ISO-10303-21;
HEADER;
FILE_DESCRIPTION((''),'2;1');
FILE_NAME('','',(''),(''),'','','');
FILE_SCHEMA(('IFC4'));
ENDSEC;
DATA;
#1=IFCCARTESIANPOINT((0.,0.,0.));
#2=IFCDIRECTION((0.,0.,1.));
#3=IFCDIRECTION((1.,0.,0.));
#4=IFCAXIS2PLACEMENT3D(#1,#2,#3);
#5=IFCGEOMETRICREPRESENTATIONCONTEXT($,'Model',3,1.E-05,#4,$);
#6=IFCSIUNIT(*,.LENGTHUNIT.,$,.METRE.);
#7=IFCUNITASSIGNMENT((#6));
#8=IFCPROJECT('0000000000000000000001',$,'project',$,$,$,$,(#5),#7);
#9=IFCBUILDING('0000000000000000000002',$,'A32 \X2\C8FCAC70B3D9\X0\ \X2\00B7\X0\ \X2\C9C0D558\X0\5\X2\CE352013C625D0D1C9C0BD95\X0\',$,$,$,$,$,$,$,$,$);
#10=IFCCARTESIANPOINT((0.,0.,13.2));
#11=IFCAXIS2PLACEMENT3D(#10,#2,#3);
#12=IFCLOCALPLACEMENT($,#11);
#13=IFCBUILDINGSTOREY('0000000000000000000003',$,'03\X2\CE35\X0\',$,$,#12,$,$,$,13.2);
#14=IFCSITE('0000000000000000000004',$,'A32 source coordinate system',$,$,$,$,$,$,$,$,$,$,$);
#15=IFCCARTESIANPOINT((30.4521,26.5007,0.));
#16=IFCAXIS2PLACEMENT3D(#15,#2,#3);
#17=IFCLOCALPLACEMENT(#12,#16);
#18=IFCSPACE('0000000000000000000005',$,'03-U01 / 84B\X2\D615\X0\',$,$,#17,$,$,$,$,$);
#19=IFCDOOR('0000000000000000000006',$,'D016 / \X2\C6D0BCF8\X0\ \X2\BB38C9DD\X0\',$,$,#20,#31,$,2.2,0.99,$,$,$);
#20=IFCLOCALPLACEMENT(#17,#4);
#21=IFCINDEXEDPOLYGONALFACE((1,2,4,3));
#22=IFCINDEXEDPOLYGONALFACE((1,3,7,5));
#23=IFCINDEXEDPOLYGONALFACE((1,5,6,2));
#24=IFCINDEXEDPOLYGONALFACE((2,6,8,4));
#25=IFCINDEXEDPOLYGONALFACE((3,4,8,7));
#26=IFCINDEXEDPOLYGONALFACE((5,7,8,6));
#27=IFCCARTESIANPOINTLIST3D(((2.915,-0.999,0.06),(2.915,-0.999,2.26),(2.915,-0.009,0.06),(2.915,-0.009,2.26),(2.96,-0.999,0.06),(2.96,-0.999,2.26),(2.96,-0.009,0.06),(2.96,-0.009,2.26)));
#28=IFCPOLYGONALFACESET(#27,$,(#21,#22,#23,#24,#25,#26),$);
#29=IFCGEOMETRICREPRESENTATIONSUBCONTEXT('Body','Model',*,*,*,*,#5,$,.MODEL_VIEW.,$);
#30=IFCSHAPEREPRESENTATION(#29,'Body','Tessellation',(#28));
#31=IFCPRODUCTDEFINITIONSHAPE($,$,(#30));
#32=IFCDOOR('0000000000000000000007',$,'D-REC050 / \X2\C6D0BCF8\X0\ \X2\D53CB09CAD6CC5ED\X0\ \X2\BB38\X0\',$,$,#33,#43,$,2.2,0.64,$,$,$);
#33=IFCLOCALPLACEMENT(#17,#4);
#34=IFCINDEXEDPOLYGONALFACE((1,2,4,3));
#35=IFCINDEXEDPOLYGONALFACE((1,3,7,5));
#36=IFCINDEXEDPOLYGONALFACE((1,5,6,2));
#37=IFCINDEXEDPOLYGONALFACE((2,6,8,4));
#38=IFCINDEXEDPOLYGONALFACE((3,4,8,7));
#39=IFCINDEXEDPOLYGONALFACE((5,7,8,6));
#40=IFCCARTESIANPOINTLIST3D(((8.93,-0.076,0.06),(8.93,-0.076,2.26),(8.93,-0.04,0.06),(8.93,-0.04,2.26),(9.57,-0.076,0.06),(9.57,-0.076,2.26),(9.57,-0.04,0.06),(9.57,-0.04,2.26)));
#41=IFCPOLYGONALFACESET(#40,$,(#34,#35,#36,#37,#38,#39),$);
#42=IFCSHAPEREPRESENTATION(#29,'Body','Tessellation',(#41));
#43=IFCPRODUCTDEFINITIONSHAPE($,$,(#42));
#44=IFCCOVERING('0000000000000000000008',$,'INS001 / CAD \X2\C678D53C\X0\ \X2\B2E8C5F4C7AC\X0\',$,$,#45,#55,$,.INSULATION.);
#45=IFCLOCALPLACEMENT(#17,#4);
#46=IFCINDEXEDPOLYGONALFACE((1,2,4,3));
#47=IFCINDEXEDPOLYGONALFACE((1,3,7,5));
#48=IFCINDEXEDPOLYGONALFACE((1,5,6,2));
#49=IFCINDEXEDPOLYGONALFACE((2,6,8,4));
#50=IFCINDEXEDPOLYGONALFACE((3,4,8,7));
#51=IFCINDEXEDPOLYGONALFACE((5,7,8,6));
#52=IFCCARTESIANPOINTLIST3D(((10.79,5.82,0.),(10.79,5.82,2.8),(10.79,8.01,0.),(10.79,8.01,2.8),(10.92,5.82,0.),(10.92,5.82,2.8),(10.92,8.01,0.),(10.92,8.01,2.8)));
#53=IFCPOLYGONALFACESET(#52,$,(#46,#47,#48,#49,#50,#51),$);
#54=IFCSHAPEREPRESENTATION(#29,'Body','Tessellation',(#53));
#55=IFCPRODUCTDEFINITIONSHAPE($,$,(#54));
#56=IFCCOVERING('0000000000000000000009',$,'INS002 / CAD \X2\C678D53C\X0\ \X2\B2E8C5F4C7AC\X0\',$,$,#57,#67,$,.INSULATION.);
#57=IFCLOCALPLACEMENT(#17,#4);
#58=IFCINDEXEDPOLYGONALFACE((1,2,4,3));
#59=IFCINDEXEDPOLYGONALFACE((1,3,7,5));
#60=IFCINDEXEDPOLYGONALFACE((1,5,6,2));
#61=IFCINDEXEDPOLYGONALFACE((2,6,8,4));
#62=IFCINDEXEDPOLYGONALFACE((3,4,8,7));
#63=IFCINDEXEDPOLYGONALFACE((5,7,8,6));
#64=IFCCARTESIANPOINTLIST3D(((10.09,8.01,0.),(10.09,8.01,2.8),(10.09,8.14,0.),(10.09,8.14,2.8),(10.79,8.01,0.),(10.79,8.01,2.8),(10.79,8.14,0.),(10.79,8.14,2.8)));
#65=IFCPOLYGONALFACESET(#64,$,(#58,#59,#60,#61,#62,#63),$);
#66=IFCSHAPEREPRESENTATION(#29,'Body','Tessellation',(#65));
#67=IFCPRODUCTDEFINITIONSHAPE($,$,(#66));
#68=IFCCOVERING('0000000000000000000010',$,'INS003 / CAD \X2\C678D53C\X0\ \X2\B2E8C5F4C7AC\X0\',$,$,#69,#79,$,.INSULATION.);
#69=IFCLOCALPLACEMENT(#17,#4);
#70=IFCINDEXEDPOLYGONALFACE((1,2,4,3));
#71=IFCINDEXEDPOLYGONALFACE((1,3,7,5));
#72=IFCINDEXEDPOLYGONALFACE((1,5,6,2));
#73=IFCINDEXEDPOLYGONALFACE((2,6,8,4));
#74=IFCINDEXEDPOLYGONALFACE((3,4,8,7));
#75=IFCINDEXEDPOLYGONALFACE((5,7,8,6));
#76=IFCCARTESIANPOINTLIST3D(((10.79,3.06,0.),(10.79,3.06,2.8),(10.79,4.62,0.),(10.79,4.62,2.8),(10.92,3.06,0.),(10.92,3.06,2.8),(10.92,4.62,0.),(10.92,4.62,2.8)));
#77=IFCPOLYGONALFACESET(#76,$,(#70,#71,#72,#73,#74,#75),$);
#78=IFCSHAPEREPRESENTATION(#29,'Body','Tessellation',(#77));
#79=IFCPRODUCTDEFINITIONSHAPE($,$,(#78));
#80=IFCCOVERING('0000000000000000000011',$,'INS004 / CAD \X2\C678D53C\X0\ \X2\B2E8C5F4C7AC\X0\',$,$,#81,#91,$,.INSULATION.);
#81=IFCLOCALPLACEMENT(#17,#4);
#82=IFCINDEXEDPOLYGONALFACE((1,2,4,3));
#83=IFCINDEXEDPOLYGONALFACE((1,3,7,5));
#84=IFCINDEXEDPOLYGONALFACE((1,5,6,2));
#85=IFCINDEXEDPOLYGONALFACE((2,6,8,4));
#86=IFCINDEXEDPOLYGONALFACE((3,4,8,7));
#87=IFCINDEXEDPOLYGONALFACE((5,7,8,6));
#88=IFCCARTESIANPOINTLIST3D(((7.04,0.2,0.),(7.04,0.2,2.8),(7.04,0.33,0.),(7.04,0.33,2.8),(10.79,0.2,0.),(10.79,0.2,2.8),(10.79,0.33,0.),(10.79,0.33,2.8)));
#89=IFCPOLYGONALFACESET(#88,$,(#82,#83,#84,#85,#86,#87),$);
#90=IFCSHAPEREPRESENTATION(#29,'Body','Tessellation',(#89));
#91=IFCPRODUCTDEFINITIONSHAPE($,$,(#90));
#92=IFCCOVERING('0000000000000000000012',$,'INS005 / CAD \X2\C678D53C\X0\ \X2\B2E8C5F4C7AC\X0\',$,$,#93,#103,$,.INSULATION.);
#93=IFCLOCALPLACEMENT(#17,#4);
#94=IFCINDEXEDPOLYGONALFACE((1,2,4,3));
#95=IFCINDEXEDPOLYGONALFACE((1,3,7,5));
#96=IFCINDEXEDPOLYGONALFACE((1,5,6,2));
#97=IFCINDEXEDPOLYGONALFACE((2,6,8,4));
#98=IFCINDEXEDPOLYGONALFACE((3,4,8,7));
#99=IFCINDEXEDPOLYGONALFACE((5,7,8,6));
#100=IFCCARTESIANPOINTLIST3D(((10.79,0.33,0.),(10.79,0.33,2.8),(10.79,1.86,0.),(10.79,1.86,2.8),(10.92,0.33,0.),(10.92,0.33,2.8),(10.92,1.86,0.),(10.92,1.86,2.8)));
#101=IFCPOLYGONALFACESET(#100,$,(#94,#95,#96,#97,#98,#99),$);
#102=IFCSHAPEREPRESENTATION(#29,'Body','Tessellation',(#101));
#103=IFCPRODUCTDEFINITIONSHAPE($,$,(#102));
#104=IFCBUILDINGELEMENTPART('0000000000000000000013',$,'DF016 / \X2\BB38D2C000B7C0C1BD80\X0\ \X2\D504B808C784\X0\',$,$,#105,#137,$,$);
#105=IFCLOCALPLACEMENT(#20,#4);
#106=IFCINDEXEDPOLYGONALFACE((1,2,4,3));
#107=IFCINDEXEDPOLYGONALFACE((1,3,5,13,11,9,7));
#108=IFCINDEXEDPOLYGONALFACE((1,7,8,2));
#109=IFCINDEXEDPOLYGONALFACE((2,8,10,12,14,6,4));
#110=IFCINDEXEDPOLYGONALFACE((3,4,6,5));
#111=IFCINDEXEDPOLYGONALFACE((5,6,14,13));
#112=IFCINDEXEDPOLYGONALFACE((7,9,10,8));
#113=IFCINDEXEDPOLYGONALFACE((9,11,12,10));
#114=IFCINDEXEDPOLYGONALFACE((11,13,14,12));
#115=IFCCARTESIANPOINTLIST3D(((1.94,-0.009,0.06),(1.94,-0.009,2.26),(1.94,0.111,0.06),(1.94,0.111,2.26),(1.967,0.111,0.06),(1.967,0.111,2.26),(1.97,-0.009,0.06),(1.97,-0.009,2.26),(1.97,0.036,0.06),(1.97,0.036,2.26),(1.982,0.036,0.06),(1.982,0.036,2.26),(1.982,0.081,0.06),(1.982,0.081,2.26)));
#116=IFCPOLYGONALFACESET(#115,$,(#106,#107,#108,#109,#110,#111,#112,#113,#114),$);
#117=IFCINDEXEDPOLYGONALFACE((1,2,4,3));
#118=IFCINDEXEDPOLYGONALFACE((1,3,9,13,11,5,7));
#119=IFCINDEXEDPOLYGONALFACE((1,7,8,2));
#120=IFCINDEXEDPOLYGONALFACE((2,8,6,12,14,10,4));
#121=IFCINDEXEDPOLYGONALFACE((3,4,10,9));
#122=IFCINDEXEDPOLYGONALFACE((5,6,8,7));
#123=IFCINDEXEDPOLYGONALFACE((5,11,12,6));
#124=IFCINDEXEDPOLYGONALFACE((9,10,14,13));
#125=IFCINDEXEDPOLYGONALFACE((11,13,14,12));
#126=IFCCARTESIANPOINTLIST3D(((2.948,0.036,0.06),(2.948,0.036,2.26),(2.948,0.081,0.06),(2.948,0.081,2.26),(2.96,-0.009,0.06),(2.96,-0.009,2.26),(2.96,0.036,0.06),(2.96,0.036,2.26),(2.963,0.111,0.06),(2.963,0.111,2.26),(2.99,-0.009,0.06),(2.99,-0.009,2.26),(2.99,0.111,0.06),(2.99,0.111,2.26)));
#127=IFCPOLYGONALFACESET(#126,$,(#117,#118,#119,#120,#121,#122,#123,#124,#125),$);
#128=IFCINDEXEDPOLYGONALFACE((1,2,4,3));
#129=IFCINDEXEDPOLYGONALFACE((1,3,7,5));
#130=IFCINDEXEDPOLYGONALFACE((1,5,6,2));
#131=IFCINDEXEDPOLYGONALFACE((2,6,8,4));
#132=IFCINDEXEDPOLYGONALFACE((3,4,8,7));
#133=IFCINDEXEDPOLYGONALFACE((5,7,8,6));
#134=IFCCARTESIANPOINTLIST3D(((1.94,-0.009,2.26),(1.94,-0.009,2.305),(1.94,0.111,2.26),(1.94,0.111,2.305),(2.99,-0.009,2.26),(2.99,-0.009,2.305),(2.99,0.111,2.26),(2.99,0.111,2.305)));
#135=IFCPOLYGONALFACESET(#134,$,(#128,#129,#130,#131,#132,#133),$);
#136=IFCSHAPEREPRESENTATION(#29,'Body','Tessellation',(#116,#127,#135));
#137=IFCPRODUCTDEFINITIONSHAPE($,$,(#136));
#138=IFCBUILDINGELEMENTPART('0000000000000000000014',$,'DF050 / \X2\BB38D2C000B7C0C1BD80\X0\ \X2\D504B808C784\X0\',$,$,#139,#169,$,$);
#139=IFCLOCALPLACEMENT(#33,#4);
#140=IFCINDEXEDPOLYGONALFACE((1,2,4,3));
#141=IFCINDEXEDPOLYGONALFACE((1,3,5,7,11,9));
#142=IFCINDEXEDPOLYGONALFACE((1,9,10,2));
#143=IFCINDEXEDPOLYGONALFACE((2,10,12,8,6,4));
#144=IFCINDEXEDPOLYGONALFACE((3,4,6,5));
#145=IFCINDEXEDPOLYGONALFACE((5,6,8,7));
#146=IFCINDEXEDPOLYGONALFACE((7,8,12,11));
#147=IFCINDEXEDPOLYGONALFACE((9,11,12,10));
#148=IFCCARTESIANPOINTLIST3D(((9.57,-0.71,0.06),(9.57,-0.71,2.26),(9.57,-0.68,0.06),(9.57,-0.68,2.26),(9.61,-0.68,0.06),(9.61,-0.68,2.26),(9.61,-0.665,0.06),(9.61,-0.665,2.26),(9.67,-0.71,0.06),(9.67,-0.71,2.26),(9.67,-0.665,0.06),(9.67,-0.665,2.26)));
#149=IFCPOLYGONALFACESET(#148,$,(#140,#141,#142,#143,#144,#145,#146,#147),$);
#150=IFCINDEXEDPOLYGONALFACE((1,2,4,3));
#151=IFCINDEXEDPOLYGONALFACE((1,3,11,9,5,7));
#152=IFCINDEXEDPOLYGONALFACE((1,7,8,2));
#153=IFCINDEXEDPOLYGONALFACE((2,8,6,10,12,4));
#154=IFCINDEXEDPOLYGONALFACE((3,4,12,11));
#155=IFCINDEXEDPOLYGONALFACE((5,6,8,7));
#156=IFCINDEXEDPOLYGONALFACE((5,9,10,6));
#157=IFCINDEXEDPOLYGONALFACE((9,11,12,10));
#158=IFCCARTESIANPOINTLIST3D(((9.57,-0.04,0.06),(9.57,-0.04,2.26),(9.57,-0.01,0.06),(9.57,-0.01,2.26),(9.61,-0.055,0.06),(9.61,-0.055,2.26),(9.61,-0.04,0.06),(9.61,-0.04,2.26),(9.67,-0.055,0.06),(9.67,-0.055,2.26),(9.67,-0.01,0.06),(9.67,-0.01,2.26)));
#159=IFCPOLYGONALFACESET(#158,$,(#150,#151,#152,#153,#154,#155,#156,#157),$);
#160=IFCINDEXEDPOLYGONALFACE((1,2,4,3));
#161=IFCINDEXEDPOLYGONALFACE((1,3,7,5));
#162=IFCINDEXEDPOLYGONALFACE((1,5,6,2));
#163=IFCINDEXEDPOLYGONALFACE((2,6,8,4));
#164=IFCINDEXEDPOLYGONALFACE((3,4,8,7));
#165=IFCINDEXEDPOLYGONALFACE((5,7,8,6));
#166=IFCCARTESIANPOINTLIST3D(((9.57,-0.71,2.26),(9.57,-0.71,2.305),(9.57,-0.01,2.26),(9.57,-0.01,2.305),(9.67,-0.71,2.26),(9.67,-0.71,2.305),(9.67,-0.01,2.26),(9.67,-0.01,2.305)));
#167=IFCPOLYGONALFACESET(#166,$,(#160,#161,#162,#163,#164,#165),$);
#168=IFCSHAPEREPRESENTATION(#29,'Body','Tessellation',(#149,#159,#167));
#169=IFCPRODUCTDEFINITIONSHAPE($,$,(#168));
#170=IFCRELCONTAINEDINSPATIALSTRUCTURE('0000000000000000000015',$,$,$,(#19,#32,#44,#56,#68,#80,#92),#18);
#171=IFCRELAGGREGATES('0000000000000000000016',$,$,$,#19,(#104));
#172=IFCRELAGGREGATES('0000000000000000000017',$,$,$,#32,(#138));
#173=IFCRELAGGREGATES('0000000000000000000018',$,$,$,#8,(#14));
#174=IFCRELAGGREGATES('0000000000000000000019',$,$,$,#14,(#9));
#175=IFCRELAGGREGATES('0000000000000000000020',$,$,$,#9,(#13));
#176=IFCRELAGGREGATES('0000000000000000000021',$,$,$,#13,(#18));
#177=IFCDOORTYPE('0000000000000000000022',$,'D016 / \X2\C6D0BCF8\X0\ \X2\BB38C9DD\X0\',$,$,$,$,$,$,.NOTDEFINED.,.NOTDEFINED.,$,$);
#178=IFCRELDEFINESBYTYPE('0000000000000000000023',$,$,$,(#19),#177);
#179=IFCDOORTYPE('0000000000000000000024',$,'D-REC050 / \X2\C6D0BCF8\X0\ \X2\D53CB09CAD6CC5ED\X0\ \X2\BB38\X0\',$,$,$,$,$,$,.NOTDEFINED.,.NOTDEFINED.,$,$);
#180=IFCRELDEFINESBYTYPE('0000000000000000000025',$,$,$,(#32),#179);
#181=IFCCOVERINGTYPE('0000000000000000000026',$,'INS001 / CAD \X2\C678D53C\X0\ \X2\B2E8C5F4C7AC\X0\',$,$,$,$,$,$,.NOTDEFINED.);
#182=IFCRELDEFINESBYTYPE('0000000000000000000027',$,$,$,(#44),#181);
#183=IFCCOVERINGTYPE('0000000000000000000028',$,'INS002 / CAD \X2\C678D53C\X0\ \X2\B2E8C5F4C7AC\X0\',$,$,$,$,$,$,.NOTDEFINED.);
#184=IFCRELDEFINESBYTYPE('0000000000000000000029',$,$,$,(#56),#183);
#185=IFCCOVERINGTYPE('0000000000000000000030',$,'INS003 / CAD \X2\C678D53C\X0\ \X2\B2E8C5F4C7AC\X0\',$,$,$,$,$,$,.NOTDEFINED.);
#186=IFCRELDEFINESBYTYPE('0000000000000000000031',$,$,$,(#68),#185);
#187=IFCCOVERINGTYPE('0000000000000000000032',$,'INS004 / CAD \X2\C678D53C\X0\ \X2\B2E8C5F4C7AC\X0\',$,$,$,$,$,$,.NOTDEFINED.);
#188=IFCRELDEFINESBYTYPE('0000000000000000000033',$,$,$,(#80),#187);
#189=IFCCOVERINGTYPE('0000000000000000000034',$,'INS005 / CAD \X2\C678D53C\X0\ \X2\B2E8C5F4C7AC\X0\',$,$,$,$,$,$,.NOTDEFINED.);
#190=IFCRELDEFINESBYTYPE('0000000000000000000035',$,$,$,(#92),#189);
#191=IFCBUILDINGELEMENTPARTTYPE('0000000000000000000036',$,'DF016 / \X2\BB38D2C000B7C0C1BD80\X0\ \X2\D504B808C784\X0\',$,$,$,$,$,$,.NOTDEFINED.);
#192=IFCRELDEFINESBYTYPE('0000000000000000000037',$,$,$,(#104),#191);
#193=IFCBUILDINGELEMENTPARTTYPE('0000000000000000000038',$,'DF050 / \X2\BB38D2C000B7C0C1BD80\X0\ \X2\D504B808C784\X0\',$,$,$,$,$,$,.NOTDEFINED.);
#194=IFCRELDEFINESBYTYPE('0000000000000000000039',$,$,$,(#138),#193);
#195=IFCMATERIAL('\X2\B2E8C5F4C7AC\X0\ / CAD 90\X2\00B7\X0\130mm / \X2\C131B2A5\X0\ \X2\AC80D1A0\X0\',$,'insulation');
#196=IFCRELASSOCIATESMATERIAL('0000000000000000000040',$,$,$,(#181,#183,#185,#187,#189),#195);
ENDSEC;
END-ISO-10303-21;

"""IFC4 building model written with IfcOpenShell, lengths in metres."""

from ifc_helpers import new_model, si_unit, frame, origin, origin_with_axes, place, context, subcontext, project, spatial, polyline, outline, extrude, source, transform, mapped, material, type_object, type_shapes, element, aggregate, save


model = new_model("IFC4")

# Units and contexts
model_context = context("Model", 3, precision=1e-05, world=origin_with_axes())
body_context = subcontext(model_context, "Body", "Model", "MODEL_VIEW")
ifc_project = project(units=[si_unit("LENGTHUNIT", "METRE")], contexts=[model_context])

# Site, building, storey, space
storey_placement = place(None, frame((0.0, 0.0, 13.2), z_axis=(0.0, 0.0, 1.0), x_axis=(1.0, 0.0, 0.0)))
space_placement = place(storey_placement, frame((30.4521, 26.5007, 0.0), z_axis=(0.0, 0.0, 1.0), x_axis=(1.0, 0.0, 0.0)))
site = spatial("IfcSite", under=ifc_project, Name="A32 source coordinate system")
building = spatial("IfcBuilding", under=site, Name="A32 주거동 · 지하5층–옥탑지붕")
storey = spatial("IfcBuildingStorey", under=building, at=storey_placement, Name="03층", Elevation=13.2)
space = spatial("IfcSpace", under=storey, at=space_placement, Name="03-U01 / 84B형")

# Doors
door_type_1 = type_object("IfcDoorType", Name="D016 / 원본 문짝", OperationType="NOTDEFINED", PredefinedType="NOTDEFINED")
shared_shape_1 = source(origin(), body_context, "Body", "SweptSolid", [
    extrude(outline(polyline([(2.96, -0.009), (2.96, -0.999), (2.915, -0.999), (2.915, -0.009), (2.96, -0.009)])), frame((0.0, 0.0, 0.06)), (0.0, 0.0, 1.0), 2.2),
])
type_shapes(door_type_1, [shared_shape_1])
door_1_placement = place(space_placement, origin_with_axes())
door_1 = element("IfcDoor", 1, at=door_1_placement, inside=space, type_object=door_type_1, Name="D016 / 원본 문짝", OverallHeight=2.2, OverallWidth=0.99, context=body_context, shape_type="MappedRepresentation", body=[
    mapped(shared_shape_1, transform((0.0, 0.0, 0.0), scale=1.0)),
])
door_type_2 = type_object("IfcDoorType", Name="D-REC050 / 원본 피난구역 문", OperationType="NOTDEFINED", PredefinedType="NOTDEFINED")
shared_shape_2 = source(origin(), body_context, "Body", "SweptSolid", [
    extrude(outline(polyline([(9.57, -0.04), (9.57, -0.076), (8.93, -0.076), (8.93, -0.04), (9.57, -0.04)])), frame((0.0, 0.0, 0.06)), (0.0, 0.0, 1.0), 2.2),
])
type_shapes(door_type_2, [shared_shape_2])
door_2_placement = place(space_placement, origin_with_axes())
door_2 = element("IfcDoor", 2, at=door_2_placement, inside=space, type_object=door_type_2, Name="D-REC050 / 원본 피난구역 문", OverallHeight=2.2, OverallWidth=0.64, context=body_context, shape_type="MappedRepresentation", body=[
    mapped(shared_shape_2, transform((0.0, 0.0, 0.0), scale=1.0)),
])

# Coverings
ifc_material = material(Name="단열재 / CAD 90·130mm / 성능 검토", Category="insulation")
covering_type_1 = type_object("IfcCoveringType", Name="INS001 / CAD 외피 단열재", PredefinedType="NOTDEFINED", material=ifc_material)
shared_shape_3 = source(origin(), body_context, "Body", "SweptSolid", [
    extrude(outline(polyline([(10.79, 5.82), (10.79, 8.01), (10.92, 8.01), (10.92, 5.82), (10.79, 5.82)])), origin(), (0.0, 0.0, 1.0), 2.8),
])
type_shapes(covering_type_1, [shared_shape_3])
covering_1_placement = place(space_placement, origin_with_axes())
element("IfcCovering", 3, at=covering_1_placement, inside=space, type_object=covering_type_1, Name="INS001 / CAD 외피 단열재", PredefinedType="INSULATION", context=body_context, shape_type="MappedRepresentation", body=[
    mapped(shared_shape_3, transform((0.0, 0.0, 0.0), scale=1.0)),
])
covering_type_2 = type_object("IfcCoveringType", Name="INS002 / CAD 외피 단열재", PredefinedType="NOTDEFINED", material=ifc_material)
shared_shape_4 = source(origin(), body_context, "Body", "SweptSolid", [
    extrude(outline(polyline([(10.79, 8.01), (10.09, 8.01), (10.09, 8.14), (10.79, 8.14), (10.79, 8.01)])), origin(), (0.0, 0.0, 1.0), 2.8),
])
type_shapes(covering_type_2, [shared_shape_4])
covering_2_placement = place(space_placement, origin_with_axes())
element("IfcCovering", 4, at=covering_2_placement, inside=space, type_object=covering_type_2, Name="INS002 / CAD 외피 단열재", PredefinedType="INSULATION", context=body_context, shape_type="MappedRepresentation", body=[
    mapped(shared_shape_4, transform((0.0, 0.0, 0.0), scale=1.0)),
])
covering_type_3 = type_object("IfcCoveringType", Name="INS003 / CAD 외피 단열재", PredefinedType="NOTDEFINED", material=ifc_material)
shared_shape_5 = source(origin(), body_context, "Body", "SweptSolid", [
    extrude(outline(polyline([(10.79, 3.06), (10.79, 4.62), (10.92, 4.62), (10.92, 3.06), (10.79, 3.06)])), origin(), (0.0, 0.0, 1.0), 2.8),
])
type_shapes(covering_type_3, [shared_shape_5])
covering_3_placement = place(space_placement, origin_with_axes())
element("IfcCovering", 5, at=covering_3_placement, inside=space, type_object=covering_type_3, Name="INS003 / CAD 외피 단열재", PredefinedType="INSULATION", context=body_context, shape_type="MappedRepresentation", body=[
    mapped(shared_shape_5, transform((0.0, 0.0, 0.0), scale=1.0)),
])
covering_type_4 = type_object("IfcCoveringType", Name="INS004 / CAD 외피 단열재", PredefinedType="NOTDEFINED", material=ifc_material)
shared_shape_6 = source(origin(), body_context, "Body", "SweptSolid", [
    extrude(outline(polyline([(7.04, 0.33), (10.79, 0.33), (10.79, 0.2), (7.04, 0.2), (7.04, 0.33)])), origin(), (0.0, 0.0, 1.0), 2.8),
])
type_shapes(covering_type_4, [shared_shape_6])
covering_4_placement = place(space_placement, origin_with_axes())
element("IfcCovering", 6, at=covering_4_placement, inside=space, type_object=covering_type_4, Name="INS004 / CAD 외피 단열재", PredefinedType="INSULATION", context=body_context, shape_type="MappedRepresentation", body=[
    mapped(shared_shape_6, transform((0.0, 0.0, 0.0), scale=1.0)),
])
covering_type_5 = type_object("IfcCoveringType", Name="INS005 / CAD 외피 단열재", PredefinedType="NOTDEFINED", material=ifc_material)
shared_shape_7 = source(origin(), body_context, "Body", "SweptSolid", [
    extrude(outline(polyline([(10.79, 0.33), (10.79, 1.86), (10.92, 1.86), (10.92, 0.33), (10.79, 0.33)])), origin(), (0.0, 0.0, 1.0), 2.8),
])
type_shapes(covering_type_5, [shared_shape_7])
covering_5_placement = place(space_placement, origin_with_axes())
element("IfcCovering", 7, at=covering_5_placement, inside=space, type_object=covering_type_5, Name="INS005 / CAD 외피 단열재", PredefinedType="INSULATION", context=body_context, shape_type="MappedRepresentation", body=[
    mapped(shared_shape_7, transform((0.0, 0.0, 0.0), scale=1.0)),
])

# Building element parts
building_element_part_type_1 = type_object("IfcBuildingElementPartType", Name="DF016 / 문틀·상부 프레임", PredefinedType="NOTDEFINED")
shared_shape_8 = source(origin(), body_context, "Body", "SweptSolid", [
    extrude(outline(polyline([(1.94, 0.111), (1.967, 0.111), (1.982, 0.081), (1.982, 0.036), (1.97, 0.036), (1.97, -0.009), (1.94, -0.009), (1.94, 0.111)])), frame((0.0, 0.0, 0.06)), (0.0, 0.0, 1.0), 2.2),
    extrude(outline(polyline([(2.96, -0.009), (2.96, 0.036), (2.948, 0.036), (2.948, 0.081), (2.963, 0.111), (2.99, 0.111), (2.99, -0.009), (2.96, -0.009)])), frame((0.0, 0.0, 0.06)), (0.0, 0.0, 1.0), 2.2),
    extrude(outline(polyline([(1.94, -0.009), (1.94, 0.111), (2.99, 0.111), (2.99, -0.009), (1.94, -0.009)])), frame((0.0, 0.0, 2.26)), (0.0, 0.0, 1.0), 0.045),
])
type_shapes(building_element_part_type_1, [shared_shape_8])
building_element_part_1_placement = place(door_1_placement, origin_with_axes())
building_element_part_1 = element("IfcBuildingElementPart", 8, at=building_element_part_1_placement, type_object=building_element_part_type_1, Name="DF016 / 문틀·상부 프레임", context=body_context, shape_type="MappedRepresentation", body=[
    mapped(shared_shape_8, transform((0.0, 0.0, 0.0), scale=1.0)),
])
aggregate(door_1, [building_element_part_1])
building_element_part_type_2 = type_object("IfcBuildingElementPartType", Name="DF050 / 문틀·상부 프레임", PredefinedType="NOTDEFINED")
shared_shape_9 = source(origin(), body_context, "Body", "SweptSolid", [
    extrude(outline(polyline([(9.57, -0.68), (9.61, -0.68), (9.61, -0.665), (9.67, -0.665), (9.67, -0.71), (9.57, -0.71), (9.57, -0.68)])), frame((0.0, 0.0, 0.06)), (0.0, 0.0, 1.0), 2.2),
    extrude(outline(polyline([(9.67, -0.01), (9.67, -0.055), (9.61, -0.055), (9.61, -0.04), (9.57, -0.04), (9.57, -0.01), (9.67, -0.01)])), frame((0.0, 0.0, 0.06)), (0.0, 0.0, 1.0), 2.2),
    extrude(outline(polyline([(9.57, -0.71), (9.57, -0.01), (9.67, -0.01), (9.67, -0.71), (9.57, -0.71)])), frame((0.0, 0.0, 2.26)), (0.0, 0.0, 1.0), 0.045),
])
type_shapes(building_element_part_type_2, [shared_shape_9])
building_element_part_2_placement = place(door_2_placement, origin_with_axes())
building_element_part_2 = element("IfcBuildingElementPart", 9, at=building_element_part_2_placement, type_object=building_element_part_type_2, Name="DF050 / 문틀·상부 프레임", context=body_context, shape_type="MappedRepresentation", body=[
    mapped(shared_shape_9, transform((0.0, 0.0, 0.0), scale=1.0)),
])
aggregate(door_2, [building_element_part_2])

save(model, "model.ifc")
